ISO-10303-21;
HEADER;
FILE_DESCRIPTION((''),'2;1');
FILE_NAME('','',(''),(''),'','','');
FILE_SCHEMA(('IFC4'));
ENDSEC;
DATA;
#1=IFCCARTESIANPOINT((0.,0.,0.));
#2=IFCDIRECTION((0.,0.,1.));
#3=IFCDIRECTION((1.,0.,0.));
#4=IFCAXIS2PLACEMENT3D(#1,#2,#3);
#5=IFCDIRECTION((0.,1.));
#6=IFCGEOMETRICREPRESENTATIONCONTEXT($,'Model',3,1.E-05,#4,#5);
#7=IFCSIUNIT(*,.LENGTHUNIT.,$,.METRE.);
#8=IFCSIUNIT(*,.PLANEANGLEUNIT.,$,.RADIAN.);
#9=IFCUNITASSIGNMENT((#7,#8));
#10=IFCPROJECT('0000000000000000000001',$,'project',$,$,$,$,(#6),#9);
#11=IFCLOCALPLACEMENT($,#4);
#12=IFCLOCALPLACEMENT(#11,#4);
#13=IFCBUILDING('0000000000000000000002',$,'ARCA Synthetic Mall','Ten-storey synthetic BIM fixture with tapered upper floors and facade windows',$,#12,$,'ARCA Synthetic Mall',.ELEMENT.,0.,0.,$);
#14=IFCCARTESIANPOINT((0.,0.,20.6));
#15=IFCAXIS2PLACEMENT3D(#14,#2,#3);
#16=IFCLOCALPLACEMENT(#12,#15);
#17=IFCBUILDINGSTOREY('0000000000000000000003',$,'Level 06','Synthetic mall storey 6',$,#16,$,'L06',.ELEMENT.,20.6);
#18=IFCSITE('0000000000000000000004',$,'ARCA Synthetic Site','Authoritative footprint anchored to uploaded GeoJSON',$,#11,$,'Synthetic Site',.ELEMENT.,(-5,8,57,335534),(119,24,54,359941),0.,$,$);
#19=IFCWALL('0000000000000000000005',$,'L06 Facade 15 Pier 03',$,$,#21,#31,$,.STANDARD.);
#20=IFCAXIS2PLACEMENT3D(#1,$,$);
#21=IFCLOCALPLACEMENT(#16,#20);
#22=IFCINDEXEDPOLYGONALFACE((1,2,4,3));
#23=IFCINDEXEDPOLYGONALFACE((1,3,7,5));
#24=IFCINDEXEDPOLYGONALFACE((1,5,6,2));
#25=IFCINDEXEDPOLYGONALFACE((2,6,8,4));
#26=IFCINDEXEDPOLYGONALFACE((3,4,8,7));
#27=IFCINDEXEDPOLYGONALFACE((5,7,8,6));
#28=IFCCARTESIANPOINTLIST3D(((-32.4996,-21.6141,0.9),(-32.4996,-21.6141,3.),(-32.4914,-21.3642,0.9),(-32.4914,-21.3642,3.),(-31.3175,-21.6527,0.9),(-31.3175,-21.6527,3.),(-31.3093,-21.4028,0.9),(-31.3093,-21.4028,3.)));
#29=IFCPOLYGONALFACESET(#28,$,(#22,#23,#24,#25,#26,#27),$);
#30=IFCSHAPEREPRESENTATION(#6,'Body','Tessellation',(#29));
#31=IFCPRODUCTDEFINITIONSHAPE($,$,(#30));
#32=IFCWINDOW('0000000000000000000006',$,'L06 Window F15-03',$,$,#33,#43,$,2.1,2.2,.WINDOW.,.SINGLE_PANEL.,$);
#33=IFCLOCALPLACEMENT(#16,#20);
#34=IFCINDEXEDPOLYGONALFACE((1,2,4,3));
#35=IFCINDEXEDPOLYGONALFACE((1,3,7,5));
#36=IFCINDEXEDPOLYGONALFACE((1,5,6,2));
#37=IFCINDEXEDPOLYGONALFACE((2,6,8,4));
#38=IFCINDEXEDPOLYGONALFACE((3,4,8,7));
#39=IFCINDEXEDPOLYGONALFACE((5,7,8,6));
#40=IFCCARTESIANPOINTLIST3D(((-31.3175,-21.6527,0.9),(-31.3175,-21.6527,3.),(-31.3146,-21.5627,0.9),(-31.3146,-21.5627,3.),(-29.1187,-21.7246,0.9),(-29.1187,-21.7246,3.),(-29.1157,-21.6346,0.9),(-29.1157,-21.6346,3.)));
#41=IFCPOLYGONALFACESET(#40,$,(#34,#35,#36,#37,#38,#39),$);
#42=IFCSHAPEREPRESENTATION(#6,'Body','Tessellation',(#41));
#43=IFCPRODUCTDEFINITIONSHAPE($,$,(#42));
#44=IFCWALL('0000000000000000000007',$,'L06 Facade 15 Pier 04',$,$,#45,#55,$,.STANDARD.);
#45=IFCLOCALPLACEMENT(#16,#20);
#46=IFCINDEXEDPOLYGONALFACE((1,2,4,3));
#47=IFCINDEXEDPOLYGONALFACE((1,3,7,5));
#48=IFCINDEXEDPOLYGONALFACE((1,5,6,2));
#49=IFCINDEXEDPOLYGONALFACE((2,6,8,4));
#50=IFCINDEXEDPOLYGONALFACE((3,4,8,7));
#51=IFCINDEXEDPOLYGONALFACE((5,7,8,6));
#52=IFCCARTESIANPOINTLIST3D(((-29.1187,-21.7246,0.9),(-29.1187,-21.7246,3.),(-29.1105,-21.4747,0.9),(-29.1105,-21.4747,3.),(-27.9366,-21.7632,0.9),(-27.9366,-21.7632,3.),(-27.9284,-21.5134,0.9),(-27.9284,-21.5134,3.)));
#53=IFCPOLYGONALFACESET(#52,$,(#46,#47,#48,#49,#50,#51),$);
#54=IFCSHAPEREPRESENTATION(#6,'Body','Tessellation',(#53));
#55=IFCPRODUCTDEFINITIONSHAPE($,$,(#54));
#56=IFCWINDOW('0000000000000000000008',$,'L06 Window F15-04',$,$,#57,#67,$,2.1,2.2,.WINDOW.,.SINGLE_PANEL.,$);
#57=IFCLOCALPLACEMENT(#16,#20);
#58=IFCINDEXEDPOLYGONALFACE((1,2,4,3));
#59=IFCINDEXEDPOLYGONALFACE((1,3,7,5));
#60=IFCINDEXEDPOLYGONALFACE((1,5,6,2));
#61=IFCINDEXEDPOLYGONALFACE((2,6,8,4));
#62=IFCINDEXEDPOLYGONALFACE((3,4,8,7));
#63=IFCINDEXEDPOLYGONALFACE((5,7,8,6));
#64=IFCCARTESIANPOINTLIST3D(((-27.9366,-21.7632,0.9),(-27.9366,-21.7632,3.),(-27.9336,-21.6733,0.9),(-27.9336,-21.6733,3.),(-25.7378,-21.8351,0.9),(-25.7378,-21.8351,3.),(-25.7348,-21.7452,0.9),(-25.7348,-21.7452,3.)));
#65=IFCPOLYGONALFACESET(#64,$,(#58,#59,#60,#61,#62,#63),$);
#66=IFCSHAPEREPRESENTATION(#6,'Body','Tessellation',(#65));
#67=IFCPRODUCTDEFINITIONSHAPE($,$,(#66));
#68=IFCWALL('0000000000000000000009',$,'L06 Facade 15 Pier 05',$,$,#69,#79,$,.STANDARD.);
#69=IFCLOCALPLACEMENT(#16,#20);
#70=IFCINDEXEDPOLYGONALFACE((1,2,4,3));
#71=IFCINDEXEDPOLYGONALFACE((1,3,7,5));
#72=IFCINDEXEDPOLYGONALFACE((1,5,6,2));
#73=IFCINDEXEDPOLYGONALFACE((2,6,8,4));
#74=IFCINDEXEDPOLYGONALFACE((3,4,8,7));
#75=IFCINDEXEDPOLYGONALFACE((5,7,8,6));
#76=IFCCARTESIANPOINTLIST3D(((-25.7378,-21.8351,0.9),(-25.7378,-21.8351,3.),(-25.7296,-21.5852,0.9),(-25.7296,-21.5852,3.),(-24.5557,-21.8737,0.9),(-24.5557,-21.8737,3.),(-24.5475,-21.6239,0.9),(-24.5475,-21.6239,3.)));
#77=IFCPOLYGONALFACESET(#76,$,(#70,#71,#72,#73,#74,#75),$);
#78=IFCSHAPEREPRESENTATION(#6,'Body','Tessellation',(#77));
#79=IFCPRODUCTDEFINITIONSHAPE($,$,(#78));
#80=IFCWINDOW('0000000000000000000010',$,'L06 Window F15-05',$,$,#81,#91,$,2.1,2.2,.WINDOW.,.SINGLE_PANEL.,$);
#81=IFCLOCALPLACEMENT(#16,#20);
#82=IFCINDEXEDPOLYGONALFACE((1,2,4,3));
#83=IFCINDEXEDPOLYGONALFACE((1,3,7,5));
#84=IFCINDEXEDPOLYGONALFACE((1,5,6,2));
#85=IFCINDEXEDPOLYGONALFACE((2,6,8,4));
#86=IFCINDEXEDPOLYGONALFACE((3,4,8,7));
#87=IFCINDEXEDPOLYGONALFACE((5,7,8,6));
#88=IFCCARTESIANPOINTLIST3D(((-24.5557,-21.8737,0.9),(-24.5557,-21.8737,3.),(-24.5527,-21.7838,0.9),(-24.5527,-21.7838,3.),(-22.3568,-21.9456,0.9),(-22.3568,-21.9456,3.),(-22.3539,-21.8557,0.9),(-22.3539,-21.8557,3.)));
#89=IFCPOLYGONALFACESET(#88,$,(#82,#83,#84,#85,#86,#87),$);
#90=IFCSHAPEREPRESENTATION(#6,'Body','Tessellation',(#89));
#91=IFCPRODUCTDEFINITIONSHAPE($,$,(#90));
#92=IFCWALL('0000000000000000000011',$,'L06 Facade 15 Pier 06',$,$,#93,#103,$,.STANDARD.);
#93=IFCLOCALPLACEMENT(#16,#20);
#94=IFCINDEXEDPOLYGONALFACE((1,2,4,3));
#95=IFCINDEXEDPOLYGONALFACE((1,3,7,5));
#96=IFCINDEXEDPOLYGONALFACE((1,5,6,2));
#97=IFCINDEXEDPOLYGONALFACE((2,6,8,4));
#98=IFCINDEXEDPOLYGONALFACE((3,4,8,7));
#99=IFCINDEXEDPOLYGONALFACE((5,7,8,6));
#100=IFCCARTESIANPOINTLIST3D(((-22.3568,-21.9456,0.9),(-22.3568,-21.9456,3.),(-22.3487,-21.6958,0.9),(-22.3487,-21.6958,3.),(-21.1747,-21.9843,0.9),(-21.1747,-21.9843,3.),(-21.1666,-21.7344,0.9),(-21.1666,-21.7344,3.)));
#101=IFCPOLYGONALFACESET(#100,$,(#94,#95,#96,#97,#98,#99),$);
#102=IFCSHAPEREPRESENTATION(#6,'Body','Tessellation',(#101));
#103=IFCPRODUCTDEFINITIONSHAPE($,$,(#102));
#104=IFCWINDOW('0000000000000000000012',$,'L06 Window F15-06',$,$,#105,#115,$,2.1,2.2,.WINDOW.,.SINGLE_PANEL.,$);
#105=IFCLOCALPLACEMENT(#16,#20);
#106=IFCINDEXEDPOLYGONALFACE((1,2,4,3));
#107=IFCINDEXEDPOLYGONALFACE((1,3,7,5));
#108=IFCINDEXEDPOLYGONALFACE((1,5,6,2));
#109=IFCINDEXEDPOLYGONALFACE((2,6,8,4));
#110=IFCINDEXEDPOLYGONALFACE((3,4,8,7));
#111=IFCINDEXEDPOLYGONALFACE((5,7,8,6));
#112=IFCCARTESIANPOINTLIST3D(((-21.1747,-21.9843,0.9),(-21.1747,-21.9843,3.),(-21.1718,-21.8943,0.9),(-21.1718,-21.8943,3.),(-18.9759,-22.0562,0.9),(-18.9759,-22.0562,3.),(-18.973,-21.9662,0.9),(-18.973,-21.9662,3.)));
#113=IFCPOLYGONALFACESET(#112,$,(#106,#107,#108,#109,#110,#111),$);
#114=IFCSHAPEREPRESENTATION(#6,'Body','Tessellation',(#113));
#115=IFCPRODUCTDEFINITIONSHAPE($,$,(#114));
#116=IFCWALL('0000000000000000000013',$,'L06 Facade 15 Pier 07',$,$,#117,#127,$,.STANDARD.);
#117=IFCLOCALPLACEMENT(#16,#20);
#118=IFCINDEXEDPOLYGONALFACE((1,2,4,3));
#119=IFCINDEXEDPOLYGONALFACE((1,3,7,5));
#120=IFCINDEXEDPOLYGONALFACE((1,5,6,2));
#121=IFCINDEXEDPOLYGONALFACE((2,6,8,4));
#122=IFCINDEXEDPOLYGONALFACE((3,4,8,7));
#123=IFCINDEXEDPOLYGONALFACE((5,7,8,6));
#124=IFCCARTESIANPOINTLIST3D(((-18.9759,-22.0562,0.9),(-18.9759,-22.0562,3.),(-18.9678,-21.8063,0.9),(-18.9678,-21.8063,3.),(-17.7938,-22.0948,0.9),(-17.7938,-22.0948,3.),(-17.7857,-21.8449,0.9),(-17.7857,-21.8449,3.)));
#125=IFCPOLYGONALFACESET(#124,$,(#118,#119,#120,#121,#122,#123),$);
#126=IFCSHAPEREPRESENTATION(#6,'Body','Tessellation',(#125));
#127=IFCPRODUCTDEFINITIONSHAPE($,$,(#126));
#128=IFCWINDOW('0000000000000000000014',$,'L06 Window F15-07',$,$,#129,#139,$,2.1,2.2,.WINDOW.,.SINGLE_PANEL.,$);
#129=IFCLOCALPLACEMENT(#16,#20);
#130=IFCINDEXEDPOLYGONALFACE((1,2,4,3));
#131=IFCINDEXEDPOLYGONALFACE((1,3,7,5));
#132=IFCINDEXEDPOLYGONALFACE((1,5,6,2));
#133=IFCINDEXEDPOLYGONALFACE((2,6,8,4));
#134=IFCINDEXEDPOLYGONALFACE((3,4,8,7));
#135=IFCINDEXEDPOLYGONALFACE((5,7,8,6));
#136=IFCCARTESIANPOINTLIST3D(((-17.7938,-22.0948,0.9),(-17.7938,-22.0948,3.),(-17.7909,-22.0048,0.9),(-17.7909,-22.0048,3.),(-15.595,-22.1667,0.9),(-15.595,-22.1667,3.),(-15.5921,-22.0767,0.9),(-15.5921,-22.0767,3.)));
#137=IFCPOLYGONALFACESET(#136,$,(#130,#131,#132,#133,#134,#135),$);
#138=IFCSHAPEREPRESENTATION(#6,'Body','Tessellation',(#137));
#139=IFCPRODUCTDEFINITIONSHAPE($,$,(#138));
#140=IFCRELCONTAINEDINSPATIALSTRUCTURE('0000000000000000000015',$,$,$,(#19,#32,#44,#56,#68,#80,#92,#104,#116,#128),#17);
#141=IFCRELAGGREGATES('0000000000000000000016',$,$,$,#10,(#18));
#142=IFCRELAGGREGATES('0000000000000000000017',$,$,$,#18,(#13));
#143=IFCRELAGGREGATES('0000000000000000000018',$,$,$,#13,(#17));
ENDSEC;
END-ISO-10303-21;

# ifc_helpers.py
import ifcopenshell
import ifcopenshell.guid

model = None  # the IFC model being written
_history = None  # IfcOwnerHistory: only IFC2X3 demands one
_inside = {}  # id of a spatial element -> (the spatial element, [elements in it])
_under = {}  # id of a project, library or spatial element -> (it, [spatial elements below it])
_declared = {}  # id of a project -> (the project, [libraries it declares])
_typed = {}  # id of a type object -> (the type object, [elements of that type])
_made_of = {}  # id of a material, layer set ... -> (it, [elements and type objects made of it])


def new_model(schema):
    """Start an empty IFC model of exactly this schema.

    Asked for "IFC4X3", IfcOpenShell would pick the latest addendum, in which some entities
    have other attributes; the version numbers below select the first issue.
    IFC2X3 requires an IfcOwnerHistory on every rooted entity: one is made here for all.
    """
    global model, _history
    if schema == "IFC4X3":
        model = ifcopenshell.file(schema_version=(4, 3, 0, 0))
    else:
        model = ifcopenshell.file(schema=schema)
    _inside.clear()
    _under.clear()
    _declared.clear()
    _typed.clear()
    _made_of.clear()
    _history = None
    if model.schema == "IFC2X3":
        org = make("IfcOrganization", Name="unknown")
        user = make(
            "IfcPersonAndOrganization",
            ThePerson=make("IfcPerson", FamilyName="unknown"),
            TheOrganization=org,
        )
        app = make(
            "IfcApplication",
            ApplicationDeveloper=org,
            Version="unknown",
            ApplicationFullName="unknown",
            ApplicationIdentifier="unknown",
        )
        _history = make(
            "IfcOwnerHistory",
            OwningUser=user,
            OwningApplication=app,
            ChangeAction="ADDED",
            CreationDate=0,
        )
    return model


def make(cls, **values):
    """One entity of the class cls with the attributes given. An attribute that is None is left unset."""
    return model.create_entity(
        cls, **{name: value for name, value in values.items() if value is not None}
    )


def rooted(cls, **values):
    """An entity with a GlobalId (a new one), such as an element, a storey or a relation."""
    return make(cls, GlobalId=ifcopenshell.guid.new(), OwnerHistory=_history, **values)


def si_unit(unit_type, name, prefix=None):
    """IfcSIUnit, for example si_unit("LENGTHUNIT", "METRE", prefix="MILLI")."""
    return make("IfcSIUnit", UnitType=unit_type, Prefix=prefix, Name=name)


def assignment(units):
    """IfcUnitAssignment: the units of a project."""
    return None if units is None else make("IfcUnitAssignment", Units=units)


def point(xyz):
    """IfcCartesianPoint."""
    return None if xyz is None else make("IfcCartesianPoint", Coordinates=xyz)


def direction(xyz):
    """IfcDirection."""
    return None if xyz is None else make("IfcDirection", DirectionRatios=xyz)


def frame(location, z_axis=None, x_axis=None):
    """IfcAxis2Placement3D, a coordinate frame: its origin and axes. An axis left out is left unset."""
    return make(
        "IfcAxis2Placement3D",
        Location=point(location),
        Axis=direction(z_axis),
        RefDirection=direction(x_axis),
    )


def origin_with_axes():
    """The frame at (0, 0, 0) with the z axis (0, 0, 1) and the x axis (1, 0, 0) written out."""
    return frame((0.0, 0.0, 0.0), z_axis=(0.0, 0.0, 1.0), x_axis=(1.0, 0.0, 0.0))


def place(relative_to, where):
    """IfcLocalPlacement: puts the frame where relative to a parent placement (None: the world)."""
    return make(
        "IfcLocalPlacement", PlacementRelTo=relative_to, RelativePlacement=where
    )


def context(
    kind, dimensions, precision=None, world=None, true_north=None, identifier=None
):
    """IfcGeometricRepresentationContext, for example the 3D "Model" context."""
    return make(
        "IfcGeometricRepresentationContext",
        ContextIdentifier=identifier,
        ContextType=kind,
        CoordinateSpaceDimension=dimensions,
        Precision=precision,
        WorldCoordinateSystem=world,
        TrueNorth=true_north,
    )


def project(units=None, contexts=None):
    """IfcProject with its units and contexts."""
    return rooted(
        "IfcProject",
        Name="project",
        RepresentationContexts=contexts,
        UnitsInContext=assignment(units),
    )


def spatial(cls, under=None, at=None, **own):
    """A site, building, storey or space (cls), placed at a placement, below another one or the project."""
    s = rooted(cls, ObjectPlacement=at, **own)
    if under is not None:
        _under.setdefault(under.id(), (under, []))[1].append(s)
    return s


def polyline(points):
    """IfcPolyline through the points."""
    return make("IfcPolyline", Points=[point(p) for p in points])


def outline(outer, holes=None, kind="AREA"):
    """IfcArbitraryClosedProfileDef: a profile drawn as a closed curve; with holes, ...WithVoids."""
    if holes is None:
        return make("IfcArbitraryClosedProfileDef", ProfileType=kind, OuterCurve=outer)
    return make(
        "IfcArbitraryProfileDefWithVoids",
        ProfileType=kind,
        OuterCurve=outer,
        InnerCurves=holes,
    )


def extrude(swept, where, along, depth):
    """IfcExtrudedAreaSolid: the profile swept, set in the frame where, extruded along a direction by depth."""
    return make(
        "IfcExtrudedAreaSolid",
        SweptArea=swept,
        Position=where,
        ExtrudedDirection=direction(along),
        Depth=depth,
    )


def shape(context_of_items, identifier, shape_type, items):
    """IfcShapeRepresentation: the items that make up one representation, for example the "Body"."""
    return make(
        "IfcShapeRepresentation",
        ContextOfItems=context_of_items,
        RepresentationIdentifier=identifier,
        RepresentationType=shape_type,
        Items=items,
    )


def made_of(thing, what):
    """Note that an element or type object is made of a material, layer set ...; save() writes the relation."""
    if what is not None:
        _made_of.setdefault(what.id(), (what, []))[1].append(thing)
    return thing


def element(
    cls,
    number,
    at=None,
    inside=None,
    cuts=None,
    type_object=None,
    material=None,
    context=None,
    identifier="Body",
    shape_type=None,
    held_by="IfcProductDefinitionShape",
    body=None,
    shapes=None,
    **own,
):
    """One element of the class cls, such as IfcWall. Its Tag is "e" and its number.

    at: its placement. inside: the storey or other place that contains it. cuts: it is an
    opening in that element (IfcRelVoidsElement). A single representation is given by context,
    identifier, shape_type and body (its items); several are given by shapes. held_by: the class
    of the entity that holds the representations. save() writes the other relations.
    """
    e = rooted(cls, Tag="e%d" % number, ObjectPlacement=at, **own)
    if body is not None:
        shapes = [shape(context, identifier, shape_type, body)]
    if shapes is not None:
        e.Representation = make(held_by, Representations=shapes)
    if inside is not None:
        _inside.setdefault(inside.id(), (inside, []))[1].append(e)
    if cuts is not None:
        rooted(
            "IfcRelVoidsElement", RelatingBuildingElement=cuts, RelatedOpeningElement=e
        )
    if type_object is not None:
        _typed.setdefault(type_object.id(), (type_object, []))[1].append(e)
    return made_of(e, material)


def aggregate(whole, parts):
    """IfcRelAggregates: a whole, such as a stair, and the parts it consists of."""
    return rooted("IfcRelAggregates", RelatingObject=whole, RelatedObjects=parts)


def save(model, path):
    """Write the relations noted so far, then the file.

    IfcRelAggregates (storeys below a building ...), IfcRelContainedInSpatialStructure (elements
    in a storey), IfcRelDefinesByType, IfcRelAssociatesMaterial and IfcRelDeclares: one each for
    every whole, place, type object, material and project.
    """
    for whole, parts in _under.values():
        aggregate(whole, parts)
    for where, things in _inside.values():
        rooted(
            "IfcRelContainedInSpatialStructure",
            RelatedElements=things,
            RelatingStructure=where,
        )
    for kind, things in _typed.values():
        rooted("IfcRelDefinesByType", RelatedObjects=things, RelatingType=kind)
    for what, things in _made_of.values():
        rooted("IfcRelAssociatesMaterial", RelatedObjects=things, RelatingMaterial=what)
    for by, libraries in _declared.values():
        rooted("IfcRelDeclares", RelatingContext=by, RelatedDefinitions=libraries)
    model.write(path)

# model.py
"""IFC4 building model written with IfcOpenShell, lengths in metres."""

from ifc_helpers import new_model, si_unit, direction, frame, origin_with_axes, place, context, project, spatial, polyline, outline, extrude, element, save


model = new_model("IFC4")

# Units and contexts
model_context = context("Model", 3, precision=1e-05, world=origin_with_axes(), true_north=direction((0.0, 1.0)))
ifc_project = project(units=[si_unit("LENGTHUNIT", "METRE"), si_unit("PLANEANGLEUNIT", "RADIAN")], contexts=[model_context])

# Site, building, storey
site_placement = place(None, origin_with_axes())
site = spatial("IfcSite", under=ifc_project, at=site_placement, Name="ARCA Synthetic Site", Description="Authoritative footprint anchored to uploaded GeoJSON", LongName="Synthetic Site", CompositionType="ELEMENT", RefLatitude=(-5, 8, 57, 335534), RefLongitude=(119, 24, 54, 359941), RefElevation=0.0)
building_placement = place(site_placement, origin_with_axes())
building = spatial("IfcBuilding", under=site, at=building_placement, Name="ARCA Synthetic Mall", Description="Ten-storey synthetic BIM fixture with tapered upper floors and facade windows", LongName="ARCA Synthetic Mall", CompositionType="ELEMENT", ElevationOfRefHeight=0.0, ElevationOfTerrain=0.0)
storey_placement = place(building_placement, frame((0.0, 0.0, 20.6), z_axis=(0.0, 0.0, 1.0), x_axis=(1.0, 0.0, 0.0)))
storey = spatial("IfcBuildingStorey", under=building, at=storey_placement, Name="Level 06", Description="Synthetic mall storey 6", LongName="L06", CompositionType="ELEMENT", Elevation=20.6)

# Wall
wall_1_placement = place(storey_placement, frame((0.0, 0.0, 0.9), z_axis=(0.0, 0.0, 1.0), x_axis=(1.0, 0.0, 0.0)))
element("IfcWall", 1, at=wall_1_placement, inside=storey, Name="L06 Facade 15 Pier 03", PredefinedType="STANDARD", context=model_context, shape_type="SweptSolid", body=[
    extrude(outline(polyline([(-32.4996, -21.6141), (-31.3175, -21.6527), (-31.3093, -21.4028), (-32.4914, -21.3642), (-32.4996, -21.6141)])), origin_with_axes(), (0.0, 0.0, 1.0), 2.1),
])

# Window
window_1_placement = place(storey_placement, frame((0.0, 0.0, 0.9), z_axis=(0.0, 0.0, 1.0), x_axis=(1.0, 0.0, 0.0)))
element("IfcWindow", 2, at=window_1_placement, inside=storey, Name="L06 Window F15-03", OverallHeight=2.1, OverallWidth=2.2, PartitioningType="SINGLE_PANEL", PredefinedType="WINDOW", context=model_context, shape_type="SweptSolid", body=[
    extrude(outline(polyline([(-31.3175, -21.6527), (-29.1187, -21.7246), (-29.1157, -21.6346), (-31.3146, -21.5627), (-31.3175, -21.6527)])), origin_with_axes(), (0.0, 0.0, 1.0), 2.1),
])

# Wall
wall_2_placement = place(storey_placement, frame((0.0, 0.0, 0.9), z_axis=(0.0, 0.0, 1.0), x_axis=(1.0, 0.0, 0.0)))
element("IfcWall", 3, at=wall_2_placement, inside=storey, Name="L06 Facade 15 Pier 04", PredefinedType="STANDARD", context=model_context, shape_type="SweptSolid", body=[
    extrude(outline(polyline([(-29.1187, -21.7246), (-27.9366, -21.7632), (-27.9284, -21.5134), (-29.1105, -21.4747), (-29.1187, -21.7246)])), origin_with_axes(), (0.0, 0.0, 1.0), 2.1),
])

# Window
window_2_placement = place(storey_placement, frame((0.0, 0.0, 0.9), z_axis=(0.0, 0.0, 1.0), x_axis=(1.0, 0.0, 0.0)))
element("IfcWindow", 4, at=window_2_placement, inside=storey, Name="L06 Window F15-04", OverallHeight=2.1, OverallWidth=2.2, PartitioningType="SINGLE_PANEL", PredefinedType="WINDOW", context=model_context, shape_type="SweptSolid", body=[
    extrude(outline(polyline([(-27.9366, -21.7632), (-25.7378, -21.8351), (-25.7348, -21.7452), (-27.9336, -21.6733), (-27.9366, -21.7632)])), origin_with_axes(), (0.0, 0.0, 1.0), 2.1),
])

# Wall
wall_3_placement = place(storey_placement, frame((0.0, 0.0, 0.9), z_axis=(0.0, 0.0, 1.0), x_axis=(1.0, 0.0, 0.0)))
element("IfcWall", 5, at=wall_3_placement, inside=storey, Name="L06 Facade 15 Pier 05", PredefinedType="STANDARD", context=model_context, shape_type="SweptSolid", body=[
    extrude(outline(polyline([(-25.7378, -21.8351), (-24.5557, -21.8737), (-24.5475, -21.6239), (-25.7296, -21.5852), (-25.7378, -21.8351)])), origin_with_axes(), (0.0, 0.0, 1.0), 2.1),
])

# Window
window_3_placement = place(storey_placement, frame((0.0, 0.0, 0.9), z_axis=(0.0, 0.0, 1.0), x_axis=(1.0, 0.0, 0.0)))
element("IfcWindow", 6, at=window_3_placement, inside=storey, Name="L06 Window F15-05", OverallHeight=2.1, OverallWidth=2.2, PartitioningType="SINGLE_PANEL", PredefinedType="WINDOW", context=model_context, shape_type="SweptSolid", body=[
    extrude(outline(polyline([(-24.5557, -21.8737), (-22.3568, -21.9456), (-22.3539, -21.8557), (-24.5527, -21.7838), (-24.5557, -21.8737)])), origin_with_axes(), (0.0, 0.0, 1.0), 2.1),
])

# Wall
wall_4_placement = place(storey_placement, frame((0.0, 0.0, 0.9), z_axis=(0.0, 0.0, 1.0), x_axis=(1.0, 0.0, 0.0)))
element("IfcWall", 7, at=wall_4_placement, inside=storey, Name="L06 Facade 15 Pier 06", PredefinedType="STANDARD", context=model_context, shape_type="SweptSolid", body=[
    extrude(outline(polyline([(-22.3568, -21.9456), (-21.1747, -21.9843), (-21.1666, -21.7344), (-22.3487, -21.6958), (-22.3568, -21.9456)])), origin_with_axes(), (0.0, 0.0, 1.0), 2.1),
])

# Window
window_4_placement = place(storey_placement, frame((0.0, 0.0, 0.9), z_axis=(0.0, 0.0, 1.0), x_axis=(1.0, 0.0, 0.0)))
element("IfcWindow", 8, at=window_4_placement, inside=storey, Name="L06 Window F15-06", OverallHeight=2.1, OverallWidth=2.2, PartitioningType="SINGLE_PANEL", PredefinedType="WINDOW", context=model_context, shape_type="SweptSolid", body=[
    extrude(outline(polyline([(-21.1747, -21.9843), (-18.9759, -22.0562), (-18.973, -21.9662), (-21.1718, -21.8943), (-21.1747, -21.9843)])), origin_with_axes(), (0.0, 0.0, 1.0), 2.1),
])

# Wall
wall_5_placement = place(storey_placement, frame((0.0, 0.0, 0.9), z_axis=(0.0, 0.0, 1.0), x_axis=(1.0, 0.0, 0.0)))
element("IfcWall", 9, at=wall_5_placement, inside=storey, Name="L06 Facade 15 Pier 07", PredefinedType="STANDARD", context=model_context, shape_type="SweptSolid", body=[
    extrude(outline(polyline([(-18.9759, -22.0562), (-17.7938, -22.0948), (-17.7857, -21.8449), (-18.9678, -21.8063), (-18.9759, -22.0562)])), origin_with_axes(), (0.0, 0.0, 1.0), 2.1),
])

# Window
window_5_placement = place(storey_placement, frame((0.0, 0.0, 0.9), z_axis=(0.0, 0.0, 1.0), x_axis=(1.0, 0.0, 0.0)))
element("IfcWindow", 10, at=window_5_placement, inside=storey, Name="L06 Window F15-07", OverallHeight=2.1, OverallWidth=2.2, PartitioningType="SINGLE_PANEL", PredefinedType="WINDOW", context=model_context, shape_type="SweptSolid", body=[
    extrude(outline(polyline([(-17.7938, -22.0948), (-15.595, -22.1667), (-15.5921, -22.0767), (-17.7909, -22.0048), (-17.7938, -22.0948)])), origin_with_axes(), (0.0, 0.0, 1.0), 2.1),
])

save(model, "model.ifc")
